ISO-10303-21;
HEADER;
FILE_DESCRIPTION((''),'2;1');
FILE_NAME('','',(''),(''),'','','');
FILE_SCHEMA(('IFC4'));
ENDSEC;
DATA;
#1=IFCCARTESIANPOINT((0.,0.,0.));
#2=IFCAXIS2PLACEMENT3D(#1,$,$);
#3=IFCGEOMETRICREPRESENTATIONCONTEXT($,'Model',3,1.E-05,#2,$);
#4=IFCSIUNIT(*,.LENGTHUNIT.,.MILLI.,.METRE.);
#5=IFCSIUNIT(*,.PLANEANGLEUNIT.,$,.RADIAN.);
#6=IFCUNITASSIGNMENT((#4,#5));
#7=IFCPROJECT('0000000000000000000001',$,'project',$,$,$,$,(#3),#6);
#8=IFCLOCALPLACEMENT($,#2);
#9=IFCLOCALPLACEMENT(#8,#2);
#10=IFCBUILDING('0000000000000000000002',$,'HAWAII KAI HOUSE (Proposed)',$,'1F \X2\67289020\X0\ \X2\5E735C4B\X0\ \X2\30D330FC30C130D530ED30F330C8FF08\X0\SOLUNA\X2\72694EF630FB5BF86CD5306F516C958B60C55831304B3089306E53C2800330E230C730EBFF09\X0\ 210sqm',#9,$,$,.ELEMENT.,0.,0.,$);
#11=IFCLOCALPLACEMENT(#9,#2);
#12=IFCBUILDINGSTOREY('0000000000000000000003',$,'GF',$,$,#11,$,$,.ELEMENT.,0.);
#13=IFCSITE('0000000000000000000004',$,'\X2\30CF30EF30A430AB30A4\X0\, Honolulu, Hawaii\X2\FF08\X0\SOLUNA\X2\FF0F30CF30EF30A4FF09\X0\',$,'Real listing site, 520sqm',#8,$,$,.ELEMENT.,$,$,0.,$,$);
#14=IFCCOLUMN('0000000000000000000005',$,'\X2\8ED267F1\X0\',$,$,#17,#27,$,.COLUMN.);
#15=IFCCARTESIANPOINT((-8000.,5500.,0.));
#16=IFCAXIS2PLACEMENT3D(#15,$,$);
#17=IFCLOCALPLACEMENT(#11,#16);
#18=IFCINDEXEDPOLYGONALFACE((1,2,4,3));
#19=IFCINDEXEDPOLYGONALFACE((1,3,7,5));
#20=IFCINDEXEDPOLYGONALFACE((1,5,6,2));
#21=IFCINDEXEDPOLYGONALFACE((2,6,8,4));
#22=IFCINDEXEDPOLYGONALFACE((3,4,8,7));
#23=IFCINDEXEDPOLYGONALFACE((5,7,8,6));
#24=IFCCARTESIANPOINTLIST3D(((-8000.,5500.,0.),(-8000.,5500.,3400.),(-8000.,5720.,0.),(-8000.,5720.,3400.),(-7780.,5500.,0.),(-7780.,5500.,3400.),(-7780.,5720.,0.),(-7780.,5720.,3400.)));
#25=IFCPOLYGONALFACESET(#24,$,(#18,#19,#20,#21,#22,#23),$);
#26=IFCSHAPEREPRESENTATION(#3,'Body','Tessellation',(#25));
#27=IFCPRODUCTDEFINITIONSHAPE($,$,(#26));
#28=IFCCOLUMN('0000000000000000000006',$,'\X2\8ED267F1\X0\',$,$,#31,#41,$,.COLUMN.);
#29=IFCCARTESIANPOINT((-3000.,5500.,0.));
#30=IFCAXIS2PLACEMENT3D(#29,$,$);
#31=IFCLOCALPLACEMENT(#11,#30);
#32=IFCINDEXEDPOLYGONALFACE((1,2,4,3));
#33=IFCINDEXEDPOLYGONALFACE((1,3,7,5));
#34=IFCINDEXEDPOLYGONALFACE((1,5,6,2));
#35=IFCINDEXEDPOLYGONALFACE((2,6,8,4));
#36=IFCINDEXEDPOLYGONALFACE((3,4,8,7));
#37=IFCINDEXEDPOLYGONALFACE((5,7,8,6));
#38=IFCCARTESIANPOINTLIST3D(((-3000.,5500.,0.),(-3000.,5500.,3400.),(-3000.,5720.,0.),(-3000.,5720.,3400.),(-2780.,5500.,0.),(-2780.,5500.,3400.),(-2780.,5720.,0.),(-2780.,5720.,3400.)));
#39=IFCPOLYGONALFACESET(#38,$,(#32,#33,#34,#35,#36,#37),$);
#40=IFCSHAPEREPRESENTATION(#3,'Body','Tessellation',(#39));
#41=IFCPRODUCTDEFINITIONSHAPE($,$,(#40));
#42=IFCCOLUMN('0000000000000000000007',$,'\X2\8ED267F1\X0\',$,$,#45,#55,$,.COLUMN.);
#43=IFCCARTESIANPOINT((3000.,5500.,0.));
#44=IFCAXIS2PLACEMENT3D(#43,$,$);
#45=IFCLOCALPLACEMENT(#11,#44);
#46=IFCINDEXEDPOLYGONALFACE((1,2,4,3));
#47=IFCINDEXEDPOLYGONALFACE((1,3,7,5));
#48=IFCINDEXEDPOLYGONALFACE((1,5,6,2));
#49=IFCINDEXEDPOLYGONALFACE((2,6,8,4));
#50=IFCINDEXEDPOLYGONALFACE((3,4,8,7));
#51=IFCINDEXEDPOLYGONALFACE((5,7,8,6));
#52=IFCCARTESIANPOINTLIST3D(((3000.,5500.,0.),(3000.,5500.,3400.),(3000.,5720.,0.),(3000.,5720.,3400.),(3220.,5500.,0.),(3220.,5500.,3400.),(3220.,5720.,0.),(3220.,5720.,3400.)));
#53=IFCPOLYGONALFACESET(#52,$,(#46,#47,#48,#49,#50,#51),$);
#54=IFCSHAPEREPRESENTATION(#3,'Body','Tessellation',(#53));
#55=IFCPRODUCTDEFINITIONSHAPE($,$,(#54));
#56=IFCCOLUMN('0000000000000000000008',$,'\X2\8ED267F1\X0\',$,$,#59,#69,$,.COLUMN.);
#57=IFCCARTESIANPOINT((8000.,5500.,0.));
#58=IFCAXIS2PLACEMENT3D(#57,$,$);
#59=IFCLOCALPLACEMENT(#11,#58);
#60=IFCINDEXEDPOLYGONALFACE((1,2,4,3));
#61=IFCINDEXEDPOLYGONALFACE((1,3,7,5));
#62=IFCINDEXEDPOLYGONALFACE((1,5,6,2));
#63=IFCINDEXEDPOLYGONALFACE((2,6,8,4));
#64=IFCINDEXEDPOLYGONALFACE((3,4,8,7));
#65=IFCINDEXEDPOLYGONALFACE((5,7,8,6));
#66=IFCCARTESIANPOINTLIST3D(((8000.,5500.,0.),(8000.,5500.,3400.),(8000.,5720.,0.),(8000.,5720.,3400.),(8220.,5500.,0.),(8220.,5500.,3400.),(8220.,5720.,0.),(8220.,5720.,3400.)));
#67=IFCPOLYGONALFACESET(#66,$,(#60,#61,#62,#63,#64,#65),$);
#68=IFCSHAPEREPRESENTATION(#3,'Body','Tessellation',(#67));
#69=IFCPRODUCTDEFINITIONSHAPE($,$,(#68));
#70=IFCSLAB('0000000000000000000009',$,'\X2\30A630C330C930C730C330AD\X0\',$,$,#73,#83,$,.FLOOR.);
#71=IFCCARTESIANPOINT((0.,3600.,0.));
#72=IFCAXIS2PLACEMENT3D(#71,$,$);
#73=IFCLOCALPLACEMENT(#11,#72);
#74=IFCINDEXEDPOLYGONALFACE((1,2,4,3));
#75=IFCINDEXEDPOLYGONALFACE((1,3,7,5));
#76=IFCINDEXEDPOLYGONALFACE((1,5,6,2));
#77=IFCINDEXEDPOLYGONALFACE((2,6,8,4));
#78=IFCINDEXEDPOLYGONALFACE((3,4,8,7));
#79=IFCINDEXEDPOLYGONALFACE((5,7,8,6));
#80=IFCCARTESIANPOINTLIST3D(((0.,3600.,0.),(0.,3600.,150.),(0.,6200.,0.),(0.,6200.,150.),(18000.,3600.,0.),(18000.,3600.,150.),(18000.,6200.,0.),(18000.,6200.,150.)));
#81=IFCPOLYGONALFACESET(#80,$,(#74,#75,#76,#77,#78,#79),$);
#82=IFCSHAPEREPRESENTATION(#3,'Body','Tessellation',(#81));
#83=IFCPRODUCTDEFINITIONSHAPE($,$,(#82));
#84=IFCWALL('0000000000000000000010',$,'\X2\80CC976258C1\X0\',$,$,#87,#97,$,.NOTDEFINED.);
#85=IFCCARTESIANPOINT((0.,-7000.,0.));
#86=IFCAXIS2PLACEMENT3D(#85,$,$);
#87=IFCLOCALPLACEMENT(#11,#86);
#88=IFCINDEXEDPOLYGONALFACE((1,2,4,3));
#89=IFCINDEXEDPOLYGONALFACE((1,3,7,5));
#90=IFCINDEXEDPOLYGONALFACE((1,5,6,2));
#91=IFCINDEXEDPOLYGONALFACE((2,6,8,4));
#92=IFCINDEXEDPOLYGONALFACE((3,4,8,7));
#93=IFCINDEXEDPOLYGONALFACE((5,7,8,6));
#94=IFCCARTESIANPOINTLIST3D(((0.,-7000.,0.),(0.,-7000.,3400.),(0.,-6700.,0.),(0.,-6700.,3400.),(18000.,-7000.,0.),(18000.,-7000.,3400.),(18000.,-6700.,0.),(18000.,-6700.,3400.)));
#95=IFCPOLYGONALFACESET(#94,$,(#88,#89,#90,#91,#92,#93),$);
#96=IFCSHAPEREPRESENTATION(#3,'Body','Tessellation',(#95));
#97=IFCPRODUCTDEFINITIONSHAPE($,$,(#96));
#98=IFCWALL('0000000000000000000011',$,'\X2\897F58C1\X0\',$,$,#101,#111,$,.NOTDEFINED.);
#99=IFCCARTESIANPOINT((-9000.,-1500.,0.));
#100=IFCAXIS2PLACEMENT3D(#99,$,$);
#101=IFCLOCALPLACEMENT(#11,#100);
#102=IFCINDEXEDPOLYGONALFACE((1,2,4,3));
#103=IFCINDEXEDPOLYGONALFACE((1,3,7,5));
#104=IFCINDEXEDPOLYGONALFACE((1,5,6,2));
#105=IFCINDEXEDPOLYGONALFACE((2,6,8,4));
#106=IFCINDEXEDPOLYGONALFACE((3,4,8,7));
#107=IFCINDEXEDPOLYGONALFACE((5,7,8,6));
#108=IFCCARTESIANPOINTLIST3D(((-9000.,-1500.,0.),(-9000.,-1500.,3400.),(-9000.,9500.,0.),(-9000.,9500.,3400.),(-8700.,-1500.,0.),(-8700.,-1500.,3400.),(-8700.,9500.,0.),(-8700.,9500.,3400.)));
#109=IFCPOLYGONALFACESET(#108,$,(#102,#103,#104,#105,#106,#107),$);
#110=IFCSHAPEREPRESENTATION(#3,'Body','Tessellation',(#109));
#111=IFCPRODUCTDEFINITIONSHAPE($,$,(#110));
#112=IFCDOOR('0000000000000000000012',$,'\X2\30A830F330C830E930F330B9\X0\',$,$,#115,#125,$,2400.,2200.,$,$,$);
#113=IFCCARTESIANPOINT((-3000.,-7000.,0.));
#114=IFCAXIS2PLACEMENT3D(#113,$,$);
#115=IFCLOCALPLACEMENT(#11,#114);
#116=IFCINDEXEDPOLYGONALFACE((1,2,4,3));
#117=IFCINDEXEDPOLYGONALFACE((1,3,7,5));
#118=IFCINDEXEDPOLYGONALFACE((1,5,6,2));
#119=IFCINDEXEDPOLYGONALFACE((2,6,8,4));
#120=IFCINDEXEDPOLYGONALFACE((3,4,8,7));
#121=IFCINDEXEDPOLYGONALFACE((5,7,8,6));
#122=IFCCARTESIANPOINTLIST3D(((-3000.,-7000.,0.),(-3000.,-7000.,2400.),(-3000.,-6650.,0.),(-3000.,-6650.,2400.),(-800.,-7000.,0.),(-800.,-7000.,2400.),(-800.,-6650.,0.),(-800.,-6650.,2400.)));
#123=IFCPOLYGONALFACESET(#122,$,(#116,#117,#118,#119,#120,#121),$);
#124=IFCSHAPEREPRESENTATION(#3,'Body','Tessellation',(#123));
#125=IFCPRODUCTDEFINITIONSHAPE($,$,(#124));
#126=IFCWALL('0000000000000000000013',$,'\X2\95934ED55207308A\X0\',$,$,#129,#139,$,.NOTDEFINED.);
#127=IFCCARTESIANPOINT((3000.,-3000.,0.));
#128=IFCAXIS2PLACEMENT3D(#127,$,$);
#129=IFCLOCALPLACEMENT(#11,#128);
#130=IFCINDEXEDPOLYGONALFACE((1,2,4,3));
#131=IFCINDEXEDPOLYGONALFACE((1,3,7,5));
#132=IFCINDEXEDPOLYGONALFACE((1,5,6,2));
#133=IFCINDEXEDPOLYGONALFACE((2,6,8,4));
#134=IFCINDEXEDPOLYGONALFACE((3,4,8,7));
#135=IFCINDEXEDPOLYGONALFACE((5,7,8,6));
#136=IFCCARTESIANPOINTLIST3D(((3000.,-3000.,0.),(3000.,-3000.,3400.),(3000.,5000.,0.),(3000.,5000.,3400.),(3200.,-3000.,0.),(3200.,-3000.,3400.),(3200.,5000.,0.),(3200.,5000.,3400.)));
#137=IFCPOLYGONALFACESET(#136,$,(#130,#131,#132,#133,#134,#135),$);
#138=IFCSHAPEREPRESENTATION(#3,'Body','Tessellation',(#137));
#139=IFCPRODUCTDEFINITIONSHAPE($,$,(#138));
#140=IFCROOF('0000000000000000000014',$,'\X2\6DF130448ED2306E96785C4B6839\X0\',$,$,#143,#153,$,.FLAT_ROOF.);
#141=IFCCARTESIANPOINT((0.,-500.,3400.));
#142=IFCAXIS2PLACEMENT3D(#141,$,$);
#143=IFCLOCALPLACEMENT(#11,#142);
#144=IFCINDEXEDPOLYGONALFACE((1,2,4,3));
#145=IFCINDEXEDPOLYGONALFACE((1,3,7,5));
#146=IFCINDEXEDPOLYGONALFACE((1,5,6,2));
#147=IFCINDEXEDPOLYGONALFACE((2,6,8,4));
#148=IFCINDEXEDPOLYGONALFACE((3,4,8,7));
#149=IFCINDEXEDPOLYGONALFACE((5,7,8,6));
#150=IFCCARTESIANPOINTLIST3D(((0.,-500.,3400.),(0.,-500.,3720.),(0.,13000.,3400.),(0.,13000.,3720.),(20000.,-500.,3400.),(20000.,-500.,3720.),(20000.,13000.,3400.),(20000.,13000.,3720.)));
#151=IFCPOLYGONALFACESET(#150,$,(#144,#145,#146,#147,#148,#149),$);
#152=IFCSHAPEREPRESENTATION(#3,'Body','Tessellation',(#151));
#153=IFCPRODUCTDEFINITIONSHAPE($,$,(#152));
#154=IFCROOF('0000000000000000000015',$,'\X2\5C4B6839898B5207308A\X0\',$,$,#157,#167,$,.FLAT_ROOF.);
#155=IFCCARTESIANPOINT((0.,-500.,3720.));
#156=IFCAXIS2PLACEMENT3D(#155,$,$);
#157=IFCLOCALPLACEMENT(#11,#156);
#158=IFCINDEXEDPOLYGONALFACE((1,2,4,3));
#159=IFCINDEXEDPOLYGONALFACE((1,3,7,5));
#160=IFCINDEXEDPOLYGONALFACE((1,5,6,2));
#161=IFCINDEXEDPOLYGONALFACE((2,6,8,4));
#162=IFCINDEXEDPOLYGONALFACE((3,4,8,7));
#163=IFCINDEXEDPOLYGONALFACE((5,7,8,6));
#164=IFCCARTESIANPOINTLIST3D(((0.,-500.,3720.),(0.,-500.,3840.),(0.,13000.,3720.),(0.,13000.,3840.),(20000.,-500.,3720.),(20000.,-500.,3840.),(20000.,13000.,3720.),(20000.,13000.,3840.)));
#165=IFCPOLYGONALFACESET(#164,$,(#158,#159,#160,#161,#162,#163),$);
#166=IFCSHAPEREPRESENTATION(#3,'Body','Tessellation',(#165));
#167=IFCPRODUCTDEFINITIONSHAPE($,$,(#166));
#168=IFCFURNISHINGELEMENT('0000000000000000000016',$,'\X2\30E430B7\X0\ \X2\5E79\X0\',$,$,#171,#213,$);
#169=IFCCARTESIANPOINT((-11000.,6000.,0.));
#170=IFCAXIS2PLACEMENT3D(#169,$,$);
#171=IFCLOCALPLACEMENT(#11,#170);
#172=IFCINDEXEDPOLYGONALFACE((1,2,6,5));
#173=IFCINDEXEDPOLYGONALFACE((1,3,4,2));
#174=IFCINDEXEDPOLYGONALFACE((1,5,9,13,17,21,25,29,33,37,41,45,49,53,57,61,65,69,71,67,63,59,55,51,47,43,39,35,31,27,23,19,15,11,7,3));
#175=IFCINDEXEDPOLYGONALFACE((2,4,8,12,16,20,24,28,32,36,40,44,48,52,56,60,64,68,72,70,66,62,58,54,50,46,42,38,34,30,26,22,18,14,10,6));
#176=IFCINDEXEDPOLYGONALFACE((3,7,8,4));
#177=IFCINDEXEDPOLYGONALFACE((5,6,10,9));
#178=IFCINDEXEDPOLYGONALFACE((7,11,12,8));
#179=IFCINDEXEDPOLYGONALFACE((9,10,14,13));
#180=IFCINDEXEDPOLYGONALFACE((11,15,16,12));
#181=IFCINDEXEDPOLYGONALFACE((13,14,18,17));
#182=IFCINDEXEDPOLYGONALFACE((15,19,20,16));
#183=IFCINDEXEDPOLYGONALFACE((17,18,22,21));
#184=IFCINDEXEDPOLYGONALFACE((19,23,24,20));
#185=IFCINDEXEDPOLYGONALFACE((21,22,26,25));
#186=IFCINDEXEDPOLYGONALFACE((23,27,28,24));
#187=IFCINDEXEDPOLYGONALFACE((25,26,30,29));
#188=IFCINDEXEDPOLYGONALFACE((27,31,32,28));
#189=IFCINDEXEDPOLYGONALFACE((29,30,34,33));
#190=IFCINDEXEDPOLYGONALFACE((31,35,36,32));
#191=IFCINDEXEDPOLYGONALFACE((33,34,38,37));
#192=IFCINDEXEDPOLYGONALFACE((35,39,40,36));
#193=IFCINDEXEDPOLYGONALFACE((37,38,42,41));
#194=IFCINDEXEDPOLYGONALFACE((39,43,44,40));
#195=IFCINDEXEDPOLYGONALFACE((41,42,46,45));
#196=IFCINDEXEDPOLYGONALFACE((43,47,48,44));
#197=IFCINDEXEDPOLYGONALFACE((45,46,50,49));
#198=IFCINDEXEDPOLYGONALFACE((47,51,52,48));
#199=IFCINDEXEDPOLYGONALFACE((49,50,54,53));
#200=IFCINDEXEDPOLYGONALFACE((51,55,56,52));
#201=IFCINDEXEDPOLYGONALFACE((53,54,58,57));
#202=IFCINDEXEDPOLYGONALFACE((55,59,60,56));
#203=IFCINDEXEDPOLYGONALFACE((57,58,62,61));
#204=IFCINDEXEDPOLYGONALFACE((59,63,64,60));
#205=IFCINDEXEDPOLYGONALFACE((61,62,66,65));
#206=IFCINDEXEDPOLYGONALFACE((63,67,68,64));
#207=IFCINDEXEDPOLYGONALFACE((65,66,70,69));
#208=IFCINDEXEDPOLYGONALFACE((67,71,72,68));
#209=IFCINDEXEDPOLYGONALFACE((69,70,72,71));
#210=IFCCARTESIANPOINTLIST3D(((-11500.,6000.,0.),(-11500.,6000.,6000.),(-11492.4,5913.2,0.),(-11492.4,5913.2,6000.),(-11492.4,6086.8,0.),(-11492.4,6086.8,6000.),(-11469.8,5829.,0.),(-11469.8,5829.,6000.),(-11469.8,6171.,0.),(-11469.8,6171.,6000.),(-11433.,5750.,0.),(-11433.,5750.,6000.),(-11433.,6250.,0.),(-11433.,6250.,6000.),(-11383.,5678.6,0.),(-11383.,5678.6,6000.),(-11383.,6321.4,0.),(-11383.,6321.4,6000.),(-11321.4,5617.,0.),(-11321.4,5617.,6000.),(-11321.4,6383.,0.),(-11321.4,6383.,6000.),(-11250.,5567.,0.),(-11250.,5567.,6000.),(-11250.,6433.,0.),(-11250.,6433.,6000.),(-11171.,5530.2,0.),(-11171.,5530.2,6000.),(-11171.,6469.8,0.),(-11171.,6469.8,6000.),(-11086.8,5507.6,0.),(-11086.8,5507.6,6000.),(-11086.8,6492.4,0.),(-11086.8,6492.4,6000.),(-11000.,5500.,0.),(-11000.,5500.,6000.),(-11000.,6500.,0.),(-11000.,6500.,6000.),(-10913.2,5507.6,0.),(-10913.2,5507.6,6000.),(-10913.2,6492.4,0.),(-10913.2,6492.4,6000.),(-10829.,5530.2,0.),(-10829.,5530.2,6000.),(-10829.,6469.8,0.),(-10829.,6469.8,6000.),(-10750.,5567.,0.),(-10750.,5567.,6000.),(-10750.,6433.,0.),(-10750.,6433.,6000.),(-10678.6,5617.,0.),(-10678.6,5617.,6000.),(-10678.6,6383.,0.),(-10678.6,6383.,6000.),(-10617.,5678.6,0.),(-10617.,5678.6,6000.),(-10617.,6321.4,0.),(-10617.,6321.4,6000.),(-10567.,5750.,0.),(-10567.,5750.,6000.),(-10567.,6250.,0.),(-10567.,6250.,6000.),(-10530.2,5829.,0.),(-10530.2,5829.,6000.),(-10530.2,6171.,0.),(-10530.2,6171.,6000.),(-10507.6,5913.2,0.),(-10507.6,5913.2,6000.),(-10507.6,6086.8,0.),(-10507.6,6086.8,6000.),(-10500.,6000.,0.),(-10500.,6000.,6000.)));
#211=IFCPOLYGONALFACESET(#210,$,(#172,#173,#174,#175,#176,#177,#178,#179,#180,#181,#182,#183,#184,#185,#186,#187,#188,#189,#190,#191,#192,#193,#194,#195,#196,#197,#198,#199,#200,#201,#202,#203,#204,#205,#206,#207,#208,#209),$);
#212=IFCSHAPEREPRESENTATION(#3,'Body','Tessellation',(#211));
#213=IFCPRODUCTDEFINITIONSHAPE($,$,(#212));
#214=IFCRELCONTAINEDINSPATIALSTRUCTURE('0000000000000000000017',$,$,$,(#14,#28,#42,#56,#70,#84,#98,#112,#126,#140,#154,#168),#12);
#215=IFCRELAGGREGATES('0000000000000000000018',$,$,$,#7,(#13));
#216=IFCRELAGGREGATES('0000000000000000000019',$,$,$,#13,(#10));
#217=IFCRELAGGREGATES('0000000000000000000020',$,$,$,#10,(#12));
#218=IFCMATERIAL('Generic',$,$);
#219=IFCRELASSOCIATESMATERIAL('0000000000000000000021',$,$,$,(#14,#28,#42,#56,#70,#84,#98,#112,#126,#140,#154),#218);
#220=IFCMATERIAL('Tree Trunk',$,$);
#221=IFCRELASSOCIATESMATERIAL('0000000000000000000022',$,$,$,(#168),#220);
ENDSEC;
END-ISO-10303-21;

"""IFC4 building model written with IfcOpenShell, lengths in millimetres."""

from ifc_helpers import new_model, si_unit, frame, frame_2d, origin, origin_2d, place, context, project, spatial, rectangle, circle, extrude, material, element, save


model = new_model("IFC4")

# Units and contexts
model_context = context("Model", 3, precision=1e-05, world=origin())
ifc_project = project(units=[si_unit("LENGTHUNIT", "METRE", prefix="MILLI"), si_unit("PLANEANGLEUNIT", "RADIAN")], contexts=[model_context])

# Site, building, storey
site_placement = place(None, origin())
site = spatial("IfcSite", under=ifc_project, at=site_placement, Name="ハワイカイ, Honolulu, Hawaii（SOLUNA／ハワイ）", ObjectType="Real listing site, 520sqm", CompositionType="ELEMENT", RefElevation=0.0)
building_placement = place(site_placement, origin())
building = spatial("IfcBuilding", under=site, at=building_placement, Name="HAWAII KAI HOUSE (Proposed)", ObjectType="1F 木造 平屋 ビーチフロント（SOLUNA物件・寸法は公開情報からの参考モデル） 210sqm", CompositionType="ELEMENT", ElevationOfRefHeight=0.0, ElevationOfTerrain=0.0)
storey_placement = place(building_placement, origin())
storey = spatial("IfcBuildingStorey", under=building, at=storey_placement, Name="GF", CompositionType="ELEMENT", Elevation=0.0)

# Columns
ifc_material_1 = material(Name="Generic")
column_1_placement = place(storey_placement, frame((-8000.0, 5500.0, 0.0)))
element("IfcColumn", 1, at=column_1_placement, inside=storey, material=ifc_material_1, Name="軒柱", PredefinedType="COLUMN", context=model_context, shape_type="SweptSolid", body=[
    extrude(rectangle(XDim=220.0, YDim=220.0, at=frame_2d((110.0, 110.0))), frame((-8000.0, 5500.0, 0.0)), (0.0, 0.0, 1.0), 3400.0),
])
column_2_placement = place(storey_placement, frame((-3000.0, 5500.0, 0.0)))
element("IfcColumn", 2, at=column_2_placement, inside=storey, material=ifc_material_1, Name="軒柱", PredefinedType="COLUMN", context=model_context, shape_type="SweptSolid", body=[
    extrude(rectangle(XDim=220.0, YDim=220.0, at=frame_2d((110.0, 110.0))), frame((-3000.0, 5500.0, 0.0)), (0.0, 0.0, 1.0), 3400.0),
])
column_3_placement = place(storey_placement, frame((3000.0, 5500.0, 0.0)))
element("IfcColumn", 3, at=column_3_placement, inside=storey, material=ifc_material_1, Name="軒柱", PredefinedType="COLUMN", context=model_context, shape_type="SweptSolid", body=[
    extrude(rectangle(XDim=220.0, YDim=220.0, at=frame_2d((110.0, 110.0))), frame((3000.0, 5500.0, 0.0)), (0.0, 0.0, 1.0), 3400.0),
])
column_4_placement = place(storey_placement, frame((8000.0, 5500.0, 0.0)))
element("IfcColumn", 4, at=column_4_placement, inside=storey, material=ifc_material_1, Name="軒柱", PredefinedType="COLUMN", context=model_context, shape_type="SweptSolid", body=[
    extrude(rectangle(XDim=220.0, YDim=220.0, at=frame_2d((110.0, 110.0))), frame((8000.0, 5500.0, 0.0)), (0.0, 0.0, 1.0), 3400.0),
])

# Slab
slab_1_placement = place(storey_placement, frame((0.0, 3600.0, 0.0)))
element("IfcSlab", 5, at=slab_1_placement, inside=storey, material=ifc_material_1, Name="ウッドデッキ", PredefinedType="FLOOR", context=model_context, shape_type="SweptSolid", body=[
    extrude(rectangle(XDim=18000.0, YDim=2600.0, at=frame_2d((9000.0, 1300.0))), frame((0.0, 3600.0, 0.0)), (0.0, 0.0, 1.0), 150.0),
])

# Walls
wall_1_placement = place(storey_placement, frame((0.0, -7000.0, 0.0)))
element("IfcWall", 6, at=wall_1_placement, inside=storey, material=ifc_material_1, Name="背面壁", PredefinedType="NOTDEFINED", context=model_context, shape_type="SweptSolid", body=[
    extrude(rectangle(XDim=18000.0, YDim=300.0, at=frame_2d((9000.0, 150.0))), frame((0.0, -7000.0, 0.0)), (0.0, 0.0, 1.0), 3400.0),
])
wall_2_placement = place(storey_placement, frame((-9000.0, -1500.0, 0.0)))
element("IfcWall", 7, at=wall_2_placement, inside=storey, material=ifc_material_1, Name="西壁", PredefinedType="NOTDEFINED", context=model_context, shape_type="SweptSolid", body=[
    extrude(rectangle(XDim=300.0, YDim=11000.0, at=frame_2d((150.0, 5500.0))), frame((-9000.0, -1500.0, 0.0)), (0.0, 0.0, 1.0), 3400.0),
])

# Door
door_placement = place(storey_placement, frame((-3000.0, -7000.0, 0.0)))
element("IfcDoor", 8, at=door_placement, inside=storey, material=ifc_material_1, Name="エントランス", OverallHeight=2400.0, OverallWidth=2200.0, context=model_context, shape_type="SweptSolid", body=[
    extrude(rectangle(XDim=2200.0, YDim=350.0, at=frame_2d((1100.0, 175.0))), frame((-3000.0, -7000.0, 0.0)), (0.0, 0.0, 1.0), 2400.0),
])

# Wall
wall_3_placement = place(storey_placement, frame((3000.0, -3000.0, 0.0)))
element("IfcWall", 9, at=wall_3_placement, inside=storey, material=ifc_material_1, Name="間仕切り", PredefinedType="NOTDEFINED", context=model_context, shape_type="SweptSolid", body=[
    extrude(rectangle(XDim=200.0, YDim=8000.0, at=frame_2d((100.0, 4000.0))), frame((3000.0, -3000.0, 0.0)), (0.0, 0.0, 1.0), 3400.0),
])

# Roofs
roof_1_placement = place(storey_placement, frame((0.0, -500.0, 3400.0)))
element("IfcRoof", 10, at=roof_1_placement, inside=storey, material=ifc_material_1, Name="深い軒の陸屋根", PredefinedType="FLAT_ROOF", context=model_context, shape_type="SweptSolid", body=[
    extrude(rectangle(XDim=20000.0, YDim=13500.0, at=frame_2d((10000.0, 6750.0))), frame((0.0, -500.0, 3400.0)), (0.0, 0.0, 1.0), 320.0),
])
roof_2_placement = place(storey_placement, frame((0.0, -500.0, 3720.0)))
element("IfcRoof", 11, at=roof_2_placement, inside=storey, material=ifc_material_1, Name="屋根見切り", PredefinedType="FLAT_ROOF", context=model_context, shape_type="SweptSolid", body=[
    extrude(rectangle(XDim=20000.0, YDim=13500.0, at=frame_2d((10000.0, 6750.0))), frame((0.0, -500.0, 3720.0)), (0.0, 0.0, 1.0), 120.0),
])

# Furnishing element
ifc_material_2 = material(Name="Tree Trunk")
furnishing_1_placement = place(storey_placement, frame((-11000.0, 6000.0, 0.0)))
element("IfcFurnishingElement", 12, at=furnishing_1_placement, inside=storey, material=ifc_material_2, Name="ヤシ 幹", context=model_context, shape_type="SweptSolid", body=[
    extrude(circle(Radius=500.0, at=origin_2d()), frame((-11000.0, 6000.0, 0.0)), (0.0, 0.0, 1.0), 6000.0),
])

save(model, "model.ifc")
